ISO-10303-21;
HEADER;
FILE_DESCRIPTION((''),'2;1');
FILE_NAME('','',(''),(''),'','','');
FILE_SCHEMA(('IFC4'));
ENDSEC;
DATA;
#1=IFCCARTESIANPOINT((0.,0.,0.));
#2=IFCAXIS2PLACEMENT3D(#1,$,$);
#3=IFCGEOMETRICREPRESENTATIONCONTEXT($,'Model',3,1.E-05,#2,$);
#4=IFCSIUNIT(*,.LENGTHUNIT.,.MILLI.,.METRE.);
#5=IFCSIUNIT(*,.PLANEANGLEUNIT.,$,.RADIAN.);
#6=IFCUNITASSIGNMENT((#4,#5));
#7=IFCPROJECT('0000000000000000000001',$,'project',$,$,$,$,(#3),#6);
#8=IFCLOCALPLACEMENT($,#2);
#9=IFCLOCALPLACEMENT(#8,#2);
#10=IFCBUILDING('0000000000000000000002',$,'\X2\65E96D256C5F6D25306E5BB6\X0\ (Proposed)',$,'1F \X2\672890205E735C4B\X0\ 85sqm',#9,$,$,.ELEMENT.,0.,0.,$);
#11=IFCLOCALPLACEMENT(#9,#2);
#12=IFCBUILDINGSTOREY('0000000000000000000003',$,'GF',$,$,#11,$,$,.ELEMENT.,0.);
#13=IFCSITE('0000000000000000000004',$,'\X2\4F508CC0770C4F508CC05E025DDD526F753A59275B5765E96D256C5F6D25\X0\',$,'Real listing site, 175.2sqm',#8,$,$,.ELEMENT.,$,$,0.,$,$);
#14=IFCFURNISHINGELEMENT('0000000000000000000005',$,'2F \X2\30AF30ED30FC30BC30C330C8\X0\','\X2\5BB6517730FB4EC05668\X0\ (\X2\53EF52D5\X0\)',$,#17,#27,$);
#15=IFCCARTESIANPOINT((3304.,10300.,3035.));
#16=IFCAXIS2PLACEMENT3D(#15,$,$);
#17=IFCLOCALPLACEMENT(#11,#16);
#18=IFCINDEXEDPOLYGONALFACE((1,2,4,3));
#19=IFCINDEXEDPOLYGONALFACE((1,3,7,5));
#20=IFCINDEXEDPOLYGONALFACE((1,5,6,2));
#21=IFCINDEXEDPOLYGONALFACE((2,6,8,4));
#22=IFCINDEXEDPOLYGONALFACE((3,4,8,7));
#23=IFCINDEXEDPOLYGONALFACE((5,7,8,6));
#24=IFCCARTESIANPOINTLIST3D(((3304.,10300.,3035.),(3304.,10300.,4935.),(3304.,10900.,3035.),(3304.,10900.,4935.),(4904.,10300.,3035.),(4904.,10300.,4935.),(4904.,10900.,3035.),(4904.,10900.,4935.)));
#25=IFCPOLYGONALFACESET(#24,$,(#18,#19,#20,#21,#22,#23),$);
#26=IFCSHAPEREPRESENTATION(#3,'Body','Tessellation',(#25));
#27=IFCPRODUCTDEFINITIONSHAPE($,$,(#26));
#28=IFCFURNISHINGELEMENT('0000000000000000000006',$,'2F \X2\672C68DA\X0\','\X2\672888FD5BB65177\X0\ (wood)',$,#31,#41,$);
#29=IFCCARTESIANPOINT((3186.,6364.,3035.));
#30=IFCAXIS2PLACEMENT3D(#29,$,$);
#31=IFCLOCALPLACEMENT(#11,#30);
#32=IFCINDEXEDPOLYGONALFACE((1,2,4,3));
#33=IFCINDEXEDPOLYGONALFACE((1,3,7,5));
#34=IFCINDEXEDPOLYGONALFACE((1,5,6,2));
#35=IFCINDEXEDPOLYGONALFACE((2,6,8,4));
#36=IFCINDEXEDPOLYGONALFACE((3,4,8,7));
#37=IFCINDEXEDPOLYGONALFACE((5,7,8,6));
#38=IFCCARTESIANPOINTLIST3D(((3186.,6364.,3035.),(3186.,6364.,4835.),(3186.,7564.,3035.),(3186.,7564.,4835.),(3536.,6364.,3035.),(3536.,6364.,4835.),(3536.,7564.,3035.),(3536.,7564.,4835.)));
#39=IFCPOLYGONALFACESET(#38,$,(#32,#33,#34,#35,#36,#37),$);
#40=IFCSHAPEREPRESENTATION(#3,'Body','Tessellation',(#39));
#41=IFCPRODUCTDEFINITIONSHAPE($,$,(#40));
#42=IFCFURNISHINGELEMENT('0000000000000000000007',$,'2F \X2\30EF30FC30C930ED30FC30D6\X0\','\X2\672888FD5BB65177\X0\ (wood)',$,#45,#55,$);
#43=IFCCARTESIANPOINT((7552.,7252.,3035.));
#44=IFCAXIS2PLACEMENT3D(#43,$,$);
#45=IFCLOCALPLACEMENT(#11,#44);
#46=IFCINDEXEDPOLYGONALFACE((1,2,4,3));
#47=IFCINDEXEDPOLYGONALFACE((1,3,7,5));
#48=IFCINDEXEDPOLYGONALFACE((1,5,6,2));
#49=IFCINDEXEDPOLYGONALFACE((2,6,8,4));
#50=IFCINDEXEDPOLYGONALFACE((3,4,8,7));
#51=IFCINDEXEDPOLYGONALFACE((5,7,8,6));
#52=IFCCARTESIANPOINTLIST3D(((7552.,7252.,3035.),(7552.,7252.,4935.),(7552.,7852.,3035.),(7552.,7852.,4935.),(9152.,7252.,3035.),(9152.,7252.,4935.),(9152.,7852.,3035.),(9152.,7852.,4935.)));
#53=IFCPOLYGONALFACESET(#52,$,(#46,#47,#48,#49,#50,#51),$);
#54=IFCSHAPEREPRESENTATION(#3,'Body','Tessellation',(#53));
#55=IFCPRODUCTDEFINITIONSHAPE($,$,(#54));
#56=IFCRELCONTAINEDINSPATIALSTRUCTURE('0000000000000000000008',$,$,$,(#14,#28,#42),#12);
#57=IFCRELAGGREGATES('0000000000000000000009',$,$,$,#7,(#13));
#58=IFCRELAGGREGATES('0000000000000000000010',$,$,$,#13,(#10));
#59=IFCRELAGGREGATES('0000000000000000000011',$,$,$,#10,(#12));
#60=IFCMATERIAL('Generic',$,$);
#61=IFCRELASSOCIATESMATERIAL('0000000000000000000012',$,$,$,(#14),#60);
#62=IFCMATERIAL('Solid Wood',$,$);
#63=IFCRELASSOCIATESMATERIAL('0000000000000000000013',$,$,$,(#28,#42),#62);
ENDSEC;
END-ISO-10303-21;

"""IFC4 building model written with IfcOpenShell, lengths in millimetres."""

from ifc_helpers import new_model, si_unit, frame, frame_2d, origin, place, context, project, spatial, rectangle, extrude, material, element, save


model = new_model("IFC4")

# Units and contexts
model_context = context("Model", 3, precision=1e-05, world=origin())
ifc_project = project(units=[si_unit("LENGTHUNIT", "METRE", prefix="MILLI"), si_unit("PLANEANGLEUNIT", "RADIAN")], contexts=[model_context])

# Site, building, storey
site_placement = place(None, origin())
site = spatial("IfcSite", under=ifc_project, at=site_placement, Name="佐賀県佐賀市川副町大字早津江津", ObjectType="Real listing site, 175.2sqm", CompositionType="ELEMENT", RefElevation=0.0)
building_placement = place(site_placement, origin())
building = spatial("IfcBuilding", under=site, at=building_placement, Name="早津江津の家 (Proposed)", ObjectType="1F 木造平屋 85sqm", CompositionType="ELEMENT", ElevationOfRefHeight=0.0, ElevationOfTerrain=0.0)
storey_placement = place(building_placement, origin())
storey = spatial("IfcBuildingStorey", under=building, at=storey_placement, Name="GF", CompositionType="ELEMENT", Elevation=0.0)

# Shared definitions
ifc_material_1 = material(Name="Solid Wood")

# Shared definitions
ifc_material_2 = material(Name="Generic")

# Furnishing elements
furnishing_1_placement = place(storey_placement, frame((3304.0, 10300.0, 3035.0)))
element("IfcFurnishingElement", 1, at=furnishing_1_placement, inside=storey, material=ifc_material_2, Name="2F クローゼット", Description="家具・什器 (可動)", context=model_context, shape_type="SweptSolid", body=[
    extrude(rectangle(XDim=1600.0, YDim=600.0, at=frame_2d((800.0, 300.0))), frame((3304.0, 10300.0, 3035.0)), (0.0, 0.0, 1.0), 1900.0),
])
furnishing_2_placement = place(storey_placement, frame((3186.0, 6364.0, 3035.0)))
element("IfcFurnishingElement", 2, at=furnishing_2_placement, inside=storey, material=ifc_material_1, Name="2F 本棚", Description="木製家具 (wood)", context=model_context, shape_type="SweptSolid", body=[
    extrude(rectangle(XDim=350.0, YDim=1200.0, at=frame_2d((175.0, 600.0))), frame((3186.0, 6364.0, 3035.0)), (0.0, 0.0, 1.0), 1800.0),
])
furnishing_3_placement = place(storey_placement, frame((7552.0, 7252.0, 3035.0)))
element("IfcFurnishingElement", 3, at=furnishing_3_placement, inside=storey, material=ifc_material_1, Name="2F ワードローブ", Description="木製家具 (wood)", context=model_context, shape_type="SweptSolid", body=[
    extrude(rectangle(XDim=1600.0, YDim=600.0, at=frame_2d((800.0, 300.0))), frame((7552.0, 7252.0, 3035.0)), (0.0, 0.0, 1.0), 1900.0),
])

save(model, "model.ifc")
